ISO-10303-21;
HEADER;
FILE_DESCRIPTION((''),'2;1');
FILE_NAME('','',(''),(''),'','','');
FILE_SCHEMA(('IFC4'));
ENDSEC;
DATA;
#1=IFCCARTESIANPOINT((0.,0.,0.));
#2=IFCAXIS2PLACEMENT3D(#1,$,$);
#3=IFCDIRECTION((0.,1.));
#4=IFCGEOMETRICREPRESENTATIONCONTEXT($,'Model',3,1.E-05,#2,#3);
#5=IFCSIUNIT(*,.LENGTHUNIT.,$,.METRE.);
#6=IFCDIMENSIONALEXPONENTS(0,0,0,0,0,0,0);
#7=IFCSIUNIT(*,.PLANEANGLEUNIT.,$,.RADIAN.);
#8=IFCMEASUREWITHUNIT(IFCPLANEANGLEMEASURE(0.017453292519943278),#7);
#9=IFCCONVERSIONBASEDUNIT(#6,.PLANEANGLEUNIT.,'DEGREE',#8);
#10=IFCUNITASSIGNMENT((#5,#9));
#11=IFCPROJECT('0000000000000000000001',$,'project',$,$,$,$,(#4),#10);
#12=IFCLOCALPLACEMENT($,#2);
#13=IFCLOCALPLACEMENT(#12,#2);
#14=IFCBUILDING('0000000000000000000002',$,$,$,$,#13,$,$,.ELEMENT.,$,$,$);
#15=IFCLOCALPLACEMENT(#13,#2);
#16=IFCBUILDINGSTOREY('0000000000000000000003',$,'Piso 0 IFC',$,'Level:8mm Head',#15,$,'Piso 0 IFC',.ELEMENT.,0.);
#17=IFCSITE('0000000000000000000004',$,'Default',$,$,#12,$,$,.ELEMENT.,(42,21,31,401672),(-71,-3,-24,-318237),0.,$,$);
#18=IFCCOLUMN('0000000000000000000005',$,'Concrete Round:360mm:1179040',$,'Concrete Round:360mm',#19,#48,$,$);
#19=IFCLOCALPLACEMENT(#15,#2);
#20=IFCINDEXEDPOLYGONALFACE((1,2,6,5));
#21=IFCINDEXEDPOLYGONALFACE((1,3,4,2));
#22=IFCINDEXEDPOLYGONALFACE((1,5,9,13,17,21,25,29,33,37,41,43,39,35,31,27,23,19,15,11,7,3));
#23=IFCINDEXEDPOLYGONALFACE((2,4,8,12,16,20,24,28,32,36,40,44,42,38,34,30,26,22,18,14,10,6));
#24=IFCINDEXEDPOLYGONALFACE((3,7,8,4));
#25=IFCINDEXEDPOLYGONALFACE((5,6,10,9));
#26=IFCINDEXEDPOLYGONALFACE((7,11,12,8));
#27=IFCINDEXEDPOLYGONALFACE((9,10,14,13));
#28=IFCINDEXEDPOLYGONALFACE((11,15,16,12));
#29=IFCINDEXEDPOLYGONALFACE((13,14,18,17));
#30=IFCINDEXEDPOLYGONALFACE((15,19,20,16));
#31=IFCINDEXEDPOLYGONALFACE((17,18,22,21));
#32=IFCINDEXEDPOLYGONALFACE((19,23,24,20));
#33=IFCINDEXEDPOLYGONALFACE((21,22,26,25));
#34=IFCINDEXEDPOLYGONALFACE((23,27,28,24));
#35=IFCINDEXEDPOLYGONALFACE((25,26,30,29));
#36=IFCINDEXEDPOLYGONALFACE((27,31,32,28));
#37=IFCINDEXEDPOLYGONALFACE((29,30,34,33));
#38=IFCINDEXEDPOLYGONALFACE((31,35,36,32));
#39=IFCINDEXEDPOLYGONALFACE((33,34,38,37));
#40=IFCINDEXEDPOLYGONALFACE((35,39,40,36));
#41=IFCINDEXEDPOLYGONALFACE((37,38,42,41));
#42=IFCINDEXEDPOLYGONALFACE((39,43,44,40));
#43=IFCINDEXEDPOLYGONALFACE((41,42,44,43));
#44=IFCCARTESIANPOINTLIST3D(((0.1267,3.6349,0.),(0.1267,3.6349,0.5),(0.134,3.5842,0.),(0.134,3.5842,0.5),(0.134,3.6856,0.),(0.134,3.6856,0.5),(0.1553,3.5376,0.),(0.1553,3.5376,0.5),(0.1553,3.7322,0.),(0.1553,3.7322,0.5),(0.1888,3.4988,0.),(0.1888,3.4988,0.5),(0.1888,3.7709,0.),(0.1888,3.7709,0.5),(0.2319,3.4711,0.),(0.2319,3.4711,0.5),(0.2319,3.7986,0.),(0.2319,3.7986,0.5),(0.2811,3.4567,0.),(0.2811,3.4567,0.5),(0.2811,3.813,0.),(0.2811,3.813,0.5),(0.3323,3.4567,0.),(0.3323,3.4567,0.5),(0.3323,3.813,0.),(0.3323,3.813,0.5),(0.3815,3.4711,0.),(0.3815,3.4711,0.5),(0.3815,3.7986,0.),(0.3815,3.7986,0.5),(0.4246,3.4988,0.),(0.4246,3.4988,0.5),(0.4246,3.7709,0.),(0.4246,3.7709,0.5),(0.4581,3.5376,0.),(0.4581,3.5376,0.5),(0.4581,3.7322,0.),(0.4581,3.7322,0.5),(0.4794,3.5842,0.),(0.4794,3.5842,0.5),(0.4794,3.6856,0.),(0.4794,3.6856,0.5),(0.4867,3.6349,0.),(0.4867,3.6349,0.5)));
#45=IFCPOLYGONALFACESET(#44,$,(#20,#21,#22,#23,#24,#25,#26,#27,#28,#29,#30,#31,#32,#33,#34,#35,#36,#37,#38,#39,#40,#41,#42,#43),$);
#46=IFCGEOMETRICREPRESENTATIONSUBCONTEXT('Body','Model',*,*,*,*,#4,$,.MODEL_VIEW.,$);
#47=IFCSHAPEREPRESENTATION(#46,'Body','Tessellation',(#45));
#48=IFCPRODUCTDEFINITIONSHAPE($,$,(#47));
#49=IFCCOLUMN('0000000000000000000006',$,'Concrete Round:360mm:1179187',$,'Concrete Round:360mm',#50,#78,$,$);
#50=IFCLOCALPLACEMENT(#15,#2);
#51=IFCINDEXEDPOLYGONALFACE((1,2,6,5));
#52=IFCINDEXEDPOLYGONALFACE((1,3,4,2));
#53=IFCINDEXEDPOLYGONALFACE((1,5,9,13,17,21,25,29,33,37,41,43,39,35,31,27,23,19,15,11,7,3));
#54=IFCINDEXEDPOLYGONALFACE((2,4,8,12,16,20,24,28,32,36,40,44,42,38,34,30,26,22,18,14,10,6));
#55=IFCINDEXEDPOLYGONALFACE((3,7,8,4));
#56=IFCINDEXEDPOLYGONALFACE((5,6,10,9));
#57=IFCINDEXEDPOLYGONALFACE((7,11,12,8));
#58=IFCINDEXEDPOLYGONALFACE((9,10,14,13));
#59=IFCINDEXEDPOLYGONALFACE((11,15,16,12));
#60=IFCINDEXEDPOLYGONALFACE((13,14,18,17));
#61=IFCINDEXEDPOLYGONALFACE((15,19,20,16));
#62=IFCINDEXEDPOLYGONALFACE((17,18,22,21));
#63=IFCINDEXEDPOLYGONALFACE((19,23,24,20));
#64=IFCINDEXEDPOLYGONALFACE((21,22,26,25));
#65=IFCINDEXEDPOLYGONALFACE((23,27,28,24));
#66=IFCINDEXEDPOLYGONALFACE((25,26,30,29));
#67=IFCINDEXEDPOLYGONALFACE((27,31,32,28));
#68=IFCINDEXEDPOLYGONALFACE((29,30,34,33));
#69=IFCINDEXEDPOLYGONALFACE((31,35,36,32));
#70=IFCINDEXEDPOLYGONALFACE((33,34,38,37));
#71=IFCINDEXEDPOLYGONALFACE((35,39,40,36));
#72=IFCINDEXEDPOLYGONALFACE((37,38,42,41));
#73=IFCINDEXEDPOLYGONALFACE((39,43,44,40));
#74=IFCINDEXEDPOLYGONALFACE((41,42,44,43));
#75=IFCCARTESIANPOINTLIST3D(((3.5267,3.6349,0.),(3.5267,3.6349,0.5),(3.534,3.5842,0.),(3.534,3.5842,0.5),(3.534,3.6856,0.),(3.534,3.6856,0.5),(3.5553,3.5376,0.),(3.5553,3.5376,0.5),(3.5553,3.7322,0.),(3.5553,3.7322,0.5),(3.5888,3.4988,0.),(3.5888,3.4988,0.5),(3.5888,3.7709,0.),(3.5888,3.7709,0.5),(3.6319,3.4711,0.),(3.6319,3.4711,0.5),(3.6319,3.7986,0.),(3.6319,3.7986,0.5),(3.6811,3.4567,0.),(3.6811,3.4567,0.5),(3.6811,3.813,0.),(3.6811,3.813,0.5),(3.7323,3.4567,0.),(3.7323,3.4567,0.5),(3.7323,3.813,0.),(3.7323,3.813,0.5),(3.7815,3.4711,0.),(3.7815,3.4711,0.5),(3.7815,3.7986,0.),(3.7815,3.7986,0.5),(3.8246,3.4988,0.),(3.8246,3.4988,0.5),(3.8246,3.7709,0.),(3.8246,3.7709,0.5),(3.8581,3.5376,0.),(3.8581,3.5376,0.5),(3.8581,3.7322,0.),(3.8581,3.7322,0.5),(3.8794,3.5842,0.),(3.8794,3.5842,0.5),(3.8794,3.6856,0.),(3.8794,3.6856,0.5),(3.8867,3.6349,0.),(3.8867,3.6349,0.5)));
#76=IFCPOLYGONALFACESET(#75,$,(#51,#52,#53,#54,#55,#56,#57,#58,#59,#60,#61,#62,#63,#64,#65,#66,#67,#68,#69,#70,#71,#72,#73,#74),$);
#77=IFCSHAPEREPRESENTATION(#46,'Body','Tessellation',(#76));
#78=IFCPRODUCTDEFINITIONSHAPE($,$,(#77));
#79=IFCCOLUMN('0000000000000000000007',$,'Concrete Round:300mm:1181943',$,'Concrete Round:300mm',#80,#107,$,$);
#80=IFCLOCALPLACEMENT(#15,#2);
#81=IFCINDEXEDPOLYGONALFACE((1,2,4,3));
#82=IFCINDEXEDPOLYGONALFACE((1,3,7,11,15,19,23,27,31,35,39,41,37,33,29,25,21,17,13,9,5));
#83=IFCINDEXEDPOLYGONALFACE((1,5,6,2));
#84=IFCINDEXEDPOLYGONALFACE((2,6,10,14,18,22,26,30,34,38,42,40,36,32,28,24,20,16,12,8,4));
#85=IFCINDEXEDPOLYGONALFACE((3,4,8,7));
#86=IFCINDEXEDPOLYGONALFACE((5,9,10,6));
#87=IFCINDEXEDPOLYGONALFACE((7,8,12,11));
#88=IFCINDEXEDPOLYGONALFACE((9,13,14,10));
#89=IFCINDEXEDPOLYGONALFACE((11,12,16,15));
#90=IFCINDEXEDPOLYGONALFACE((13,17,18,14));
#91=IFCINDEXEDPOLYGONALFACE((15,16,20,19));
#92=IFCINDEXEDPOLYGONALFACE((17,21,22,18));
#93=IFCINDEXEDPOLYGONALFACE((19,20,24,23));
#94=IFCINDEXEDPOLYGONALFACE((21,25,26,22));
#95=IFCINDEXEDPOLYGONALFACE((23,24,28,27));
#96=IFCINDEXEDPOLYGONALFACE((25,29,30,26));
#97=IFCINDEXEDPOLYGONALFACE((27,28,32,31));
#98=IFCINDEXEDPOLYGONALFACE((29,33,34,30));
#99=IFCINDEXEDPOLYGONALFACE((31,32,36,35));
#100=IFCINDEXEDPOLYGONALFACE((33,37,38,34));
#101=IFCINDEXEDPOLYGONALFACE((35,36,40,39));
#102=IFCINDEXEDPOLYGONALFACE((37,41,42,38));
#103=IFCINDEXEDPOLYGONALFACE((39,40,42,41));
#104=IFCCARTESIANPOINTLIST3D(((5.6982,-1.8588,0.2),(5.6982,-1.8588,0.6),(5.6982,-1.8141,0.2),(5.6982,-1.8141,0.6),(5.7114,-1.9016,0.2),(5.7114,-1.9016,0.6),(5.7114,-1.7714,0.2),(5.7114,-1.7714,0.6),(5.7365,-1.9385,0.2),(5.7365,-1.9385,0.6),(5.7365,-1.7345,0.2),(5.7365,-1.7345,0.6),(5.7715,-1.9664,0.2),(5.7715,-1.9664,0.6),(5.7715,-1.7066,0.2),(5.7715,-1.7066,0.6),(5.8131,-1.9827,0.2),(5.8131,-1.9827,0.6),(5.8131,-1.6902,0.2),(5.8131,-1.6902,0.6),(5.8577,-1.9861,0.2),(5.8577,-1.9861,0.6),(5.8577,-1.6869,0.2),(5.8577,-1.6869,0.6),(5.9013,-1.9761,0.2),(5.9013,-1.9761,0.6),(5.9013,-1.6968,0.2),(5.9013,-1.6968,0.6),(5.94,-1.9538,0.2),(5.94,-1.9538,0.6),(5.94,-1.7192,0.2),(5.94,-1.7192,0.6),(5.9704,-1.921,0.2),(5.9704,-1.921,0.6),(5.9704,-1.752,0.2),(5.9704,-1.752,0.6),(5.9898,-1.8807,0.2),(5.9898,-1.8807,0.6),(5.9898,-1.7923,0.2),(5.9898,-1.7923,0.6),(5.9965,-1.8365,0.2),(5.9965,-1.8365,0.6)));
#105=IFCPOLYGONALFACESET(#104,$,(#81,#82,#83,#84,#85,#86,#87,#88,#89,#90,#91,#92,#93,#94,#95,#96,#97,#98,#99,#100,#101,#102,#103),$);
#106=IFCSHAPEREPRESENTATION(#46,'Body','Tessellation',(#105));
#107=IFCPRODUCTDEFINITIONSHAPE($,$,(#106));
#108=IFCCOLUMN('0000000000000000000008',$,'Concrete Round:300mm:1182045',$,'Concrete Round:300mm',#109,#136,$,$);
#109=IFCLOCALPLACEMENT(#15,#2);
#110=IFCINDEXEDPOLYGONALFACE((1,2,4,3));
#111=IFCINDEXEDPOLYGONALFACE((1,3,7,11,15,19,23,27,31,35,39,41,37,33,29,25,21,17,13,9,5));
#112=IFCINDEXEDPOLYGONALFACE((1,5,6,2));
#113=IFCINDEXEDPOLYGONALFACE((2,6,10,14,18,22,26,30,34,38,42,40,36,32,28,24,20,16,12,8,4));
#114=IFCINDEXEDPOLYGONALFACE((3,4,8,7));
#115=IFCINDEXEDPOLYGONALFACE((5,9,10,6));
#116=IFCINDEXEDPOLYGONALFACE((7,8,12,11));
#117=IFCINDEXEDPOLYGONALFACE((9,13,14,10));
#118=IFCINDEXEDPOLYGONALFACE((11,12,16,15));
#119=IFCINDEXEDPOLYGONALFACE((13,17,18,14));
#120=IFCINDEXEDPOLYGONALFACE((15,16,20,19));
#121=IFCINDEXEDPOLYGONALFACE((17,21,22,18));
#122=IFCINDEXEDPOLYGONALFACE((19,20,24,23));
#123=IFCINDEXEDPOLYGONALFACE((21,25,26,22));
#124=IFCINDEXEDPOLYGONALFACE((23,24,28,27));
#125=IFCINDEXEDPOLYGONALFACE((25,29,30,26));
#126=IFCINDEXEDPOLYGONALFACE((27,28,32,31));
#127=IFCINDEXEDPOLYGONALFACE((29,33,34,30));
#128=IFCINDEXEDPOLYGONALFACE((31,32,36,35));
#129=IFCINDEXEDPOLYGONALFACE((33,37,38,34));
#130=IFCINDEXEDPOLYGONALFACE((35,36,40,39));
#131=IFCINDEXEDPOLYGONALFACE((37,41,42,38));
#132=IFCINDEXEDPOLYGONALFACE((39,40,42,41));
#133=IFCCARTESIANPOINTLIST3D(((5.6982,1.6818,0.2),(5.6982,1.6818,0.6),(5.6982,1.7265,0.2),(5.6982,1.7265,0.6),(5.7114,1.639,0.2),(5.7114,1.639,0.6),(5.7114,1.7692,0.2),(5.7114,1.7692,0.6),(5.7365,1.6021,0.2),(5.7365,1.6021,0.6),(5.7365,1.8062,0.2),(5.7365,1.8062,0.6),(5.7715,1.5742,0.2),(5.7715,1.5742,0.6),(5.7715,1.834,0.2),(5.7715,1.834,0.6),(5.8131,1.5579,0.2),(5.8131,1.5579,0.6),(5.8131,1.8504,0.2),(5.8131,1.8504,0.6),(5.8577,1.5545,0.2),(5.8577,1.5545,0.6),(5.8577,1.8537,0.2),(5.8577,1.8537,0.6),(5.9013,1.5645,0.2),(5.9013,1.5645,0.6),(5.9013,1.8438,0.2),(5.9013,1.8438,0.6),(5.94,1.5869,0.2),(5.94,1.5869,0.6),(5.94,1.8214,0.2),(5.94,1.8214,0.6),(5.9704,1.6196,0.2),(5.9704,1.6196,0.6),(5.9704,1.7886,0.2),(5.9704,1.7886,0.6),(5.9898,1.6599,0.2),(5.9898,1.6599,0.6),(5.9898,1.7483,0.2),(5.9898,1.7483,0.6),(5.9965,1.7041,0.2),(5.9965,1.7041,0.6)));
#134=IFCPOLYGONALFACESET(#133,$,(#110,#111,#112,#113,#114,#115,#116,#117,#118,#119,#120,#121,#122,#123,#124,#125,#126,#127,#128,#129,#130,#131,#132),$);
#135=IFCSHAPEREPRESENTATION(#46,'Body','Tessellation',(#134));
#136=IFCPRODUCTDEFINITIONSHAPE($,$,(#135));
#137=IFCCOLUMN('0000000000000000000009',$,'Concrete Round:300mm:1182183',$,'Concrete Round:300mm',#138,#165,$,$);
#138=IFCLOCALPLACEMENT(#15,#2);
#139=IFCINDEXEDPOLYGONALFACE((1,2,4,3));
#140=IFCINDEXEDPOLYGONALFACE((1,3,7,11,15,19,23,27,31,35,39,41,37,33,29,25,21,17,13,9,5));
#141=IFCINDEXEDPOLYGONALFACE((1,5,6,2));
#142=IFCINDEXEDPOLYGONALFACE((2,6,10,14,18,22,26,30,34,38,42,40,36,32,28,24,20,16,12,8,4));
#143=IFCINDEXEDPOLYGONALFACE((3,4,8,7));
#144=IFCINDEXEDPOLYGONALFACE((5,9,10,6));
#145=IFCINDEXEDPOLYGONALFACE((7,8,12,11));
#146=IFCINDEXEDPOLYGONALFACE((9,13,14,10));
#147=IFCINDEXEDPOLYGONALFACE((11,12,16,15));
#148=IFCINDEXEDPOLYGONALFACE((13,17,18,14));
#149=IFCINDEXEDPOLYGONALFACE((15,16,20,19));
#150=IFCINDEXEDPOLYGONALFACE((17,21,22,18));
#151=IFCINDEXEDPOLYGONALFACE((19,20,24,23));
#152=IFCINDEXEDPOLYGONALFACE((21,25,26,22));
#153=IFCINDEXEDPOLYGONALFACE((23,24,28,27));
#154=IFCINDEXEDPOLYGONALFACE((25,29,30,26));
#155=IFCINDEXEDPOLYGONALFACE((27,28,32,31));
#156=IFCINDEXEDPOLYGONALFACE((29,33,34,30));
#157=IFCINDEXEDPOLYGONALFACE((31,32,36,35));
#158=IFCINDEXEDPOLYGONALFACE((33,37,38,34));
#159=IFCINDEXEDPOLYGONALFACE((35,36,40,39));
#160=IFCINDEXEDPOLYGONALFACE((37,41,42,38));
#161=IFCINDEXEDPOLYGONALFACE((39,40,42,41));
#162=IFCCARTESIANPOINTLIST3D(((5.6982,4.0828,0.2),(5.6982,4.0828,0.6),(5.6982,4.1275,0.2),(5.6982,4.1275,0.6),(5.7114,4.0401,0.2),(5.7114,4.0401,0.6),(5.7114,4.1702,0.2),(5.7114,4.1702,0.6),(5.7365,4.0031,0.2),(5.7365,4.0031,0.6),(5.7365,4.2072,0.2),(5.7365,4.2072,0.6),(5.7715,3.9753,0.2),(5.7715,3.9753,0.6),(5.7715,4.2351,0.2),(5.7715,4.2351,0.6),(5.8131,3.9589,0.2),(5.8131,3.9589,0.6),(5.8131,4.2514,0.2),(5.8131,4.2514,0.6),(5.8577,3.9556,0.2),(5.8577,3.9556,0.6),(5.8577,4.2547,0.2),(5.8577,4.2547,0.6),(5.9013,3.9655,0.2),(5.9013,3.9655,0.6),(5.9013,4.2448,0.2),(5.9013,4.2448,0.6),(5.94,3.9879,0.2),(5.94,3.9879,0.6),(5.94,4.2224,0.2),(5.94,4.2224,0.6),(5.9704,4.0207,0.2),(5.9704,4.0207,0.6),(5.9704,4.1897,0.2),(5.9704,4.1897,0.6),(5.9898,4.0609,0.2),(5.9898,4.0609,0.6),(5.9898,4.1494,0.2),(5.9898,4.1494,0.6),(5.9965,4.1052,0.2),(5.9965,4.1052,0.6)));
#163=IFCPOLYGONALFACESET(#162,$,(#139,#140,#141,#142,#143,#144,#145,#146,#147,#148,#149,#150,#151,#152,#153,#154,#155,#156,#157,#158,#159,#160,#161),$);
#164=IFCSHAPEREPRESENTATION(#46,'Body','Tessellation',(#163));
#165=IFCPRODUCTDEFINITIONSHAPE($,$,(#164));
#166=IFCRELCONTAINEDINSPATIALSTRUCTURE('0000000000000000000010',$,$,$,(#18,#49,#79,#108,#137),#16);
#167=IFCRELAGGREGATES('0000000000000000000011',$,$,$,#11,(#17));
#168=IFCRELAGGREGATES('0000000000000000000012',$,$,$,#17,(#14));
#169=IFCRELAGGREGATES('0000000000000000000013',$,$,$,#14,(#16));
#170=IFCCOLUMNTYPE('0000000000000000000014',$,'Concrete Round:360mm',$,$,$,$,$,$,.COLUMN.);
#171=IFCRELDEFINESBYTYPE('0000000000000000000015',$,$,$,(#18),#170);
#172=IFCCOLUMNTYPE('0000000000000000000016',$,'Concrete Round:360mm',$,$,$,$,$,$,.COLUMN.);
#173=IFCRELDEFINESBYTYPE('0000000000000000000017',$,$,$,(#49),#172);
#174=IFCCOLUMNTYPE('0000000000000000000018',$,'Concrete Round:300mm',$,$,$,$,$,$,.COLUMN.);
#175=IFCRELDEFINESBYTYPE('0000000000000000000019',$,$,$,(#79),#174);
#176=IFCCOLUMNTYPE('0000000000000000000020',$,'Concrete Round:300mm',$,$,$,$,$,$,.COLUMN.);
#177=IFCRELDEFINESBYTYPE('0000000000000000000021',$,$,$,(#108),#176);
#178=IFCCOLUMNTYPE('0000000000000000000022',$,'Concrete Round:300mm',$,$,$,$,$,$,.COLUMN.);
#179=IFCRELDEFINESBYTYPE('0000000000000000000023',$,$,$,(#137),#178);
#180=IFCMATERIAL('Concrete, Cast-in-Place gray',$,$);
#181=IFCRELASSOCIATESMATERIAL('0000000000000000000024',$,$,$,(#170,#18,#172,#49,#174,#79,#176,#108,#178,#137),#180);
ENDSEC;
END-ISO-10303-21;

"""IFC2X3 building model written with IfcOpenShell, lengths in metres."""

from ifc_helpers import new_model, entity, si_unit, converted_unit, direction, frame, frame_2d, origin, origin_2d_with_axis, place, context, subcontext, project, spatial, circle, extrude, source, transform, mapped, material, type_object, type_shapes, element, save


model = new_model("IFC2X3")

# Units and contexts
model_context = context("Model", 3, precision=1e-05, world=origin(), true_north=direction((0.0, 1.0)))
body_context = subcontext(model_context, "Body", "Model", "MODEL_VIEW")
ifc_project = project(units=[si_unit("LENGTHUNIT", "METRE"), converted_unit("PLANEANGLEUNIT", "DEGREE", entity("IfcPlaneAngleMeasure", 0.017453292519943278), si_unit("PLANEANGLEUNIT", "RADIAN"), dimensions=[0, 0, 0, 0, 0, 0, 0])], contexts=[model_context])

# Site, building, storey
site_placement = place(None, origin())
site = spatial("IfcSite", under=ifc_project, at=site_placement, Name="Default", CompositionType="ELEMENT", RefLatitude=(42, 21, 31, 401672), RefLongitude=(-71, -3, -24, -318237), RefElevation=0.0)
building_placement = place(site_placement, origin())
building = spatial("IfcBuilding", under=site, at=building_placement, CompositionType="ELEMENT")
storey_placement = place(building_placement, origin())
storey = spatial("IfcBuildingStorey", under=building, at=storey_placement, Name="Piso 0 IFC", ObjectType="Level:8mm Head", LongName="Piso 0 IFC", CompositionType="ELEMENT", Elevation=0.0)

# Columns
ifc_material_1 = material(Name="Concrete, Cast-in-Place gray")
column_type_1 = type_object("IfcColumnType", Name="Concrete Round:360mm", PredefinedType="COLUMN", material=ifc_material_1)
shared_shape_1 = source(origin(), body_context, "Body", "SweptSolid", [
    extrude(circle(Radius=0.18, at=origin_2d_with_axis()), frame((0.3067, 3.6349, 0.0)), (0.0, 0.0, 1.0), 0.5),
])
type_shapes(column_type_1, [shared_shape_1])
column_1_placement = place(storey_placement, origin())
element("IfcColumn", 1, at=column_1_placement, inside=storey, type_object=column_type_1, material=ifc_material_1, Name="Concrete Round:360mm:1179040", ObjectType="Concrete Round:360mm", context=body_context, shape_type="MappedRepresentation", body=[
    mapped(shared_shape_1, transform((0.0, 0.0, 0.0), scale=1.0)),
])
column_type_2 = type_object("IfcColumnType", Name="Concrete Round:360mm", PredefinedType="COLUMN", material=ifc_material_1)
shared_shape_2 = source(origin(), body_context, "Body", "SweptSolid", [
    extrude(circle(Radius=0.18, at=origin_2d_with_axis()), frame((3.7067, 3.6349, 0.0)), (0.0, 0.0, 1.0), 0.5),
])
type_shapes(column_type_2, [shared_shape_2])
column_2_placement = place(storey_placement, origin())
element("IfcColumn", 2, at=column_2_placement, inside=storey, type_object=column_type_2, material=ifc_material_1, Name="Concrete Round:360mm:1179187", ObjectType="Concrete Round:360mm", context=body_context, shape_type="MappedRepresentation", body=[
    mapped(shared_shape_2, transform((0.0, 0.0, 0.0), scale=1.0)),
])
column_type_3 = type_object("IfcColumnType", Name="Concrete Round:300mm", PredefinedType="COLUMN", material=ifc_material_1)
shared_shape_3 = source(origin(), body_context, "Body", "SweptSolid", [
    extrude(circle(Radius=0.15, at=frame_2d((0.0, 0.0), x_axis=(1.0, 0.0))), frame((5.8465, -1.8365, 0.2)), (0.0, 0.0, 1.0), 0.4),
])
type_shapes(column_type_3, [shared_shape_3])
column_3_placement = place(storey_placement, origin())
element("IfcColumn", 3, at=column_3_placement, inside=storey, type_object=column_type_3, material=ifc_material_1, Name="Concrete Round:300mm:1181943", ObjectType="Concrete Round:300mm", context=body_context, shape_type="MappedRepresentation", body=[
    mapped(shared_shape_3, transform((0.0, 0.0, 0.0), scale=1.0)),
])
column_type_4 = type_object("IfcColumnType", Name="Concrete Round:300mm", PredefinedType="COLUMN", material=ifc_material_1)
shared_shape_4 = source(origin(), body_context, "Body", "SweptSolid", [
    extrude(circle(Radius=0.15, at=frame_2d((0.0, 0.0), x_axis=(1.0, 0.0))), frame((5.8465, 1.7041, 0.2)), (0.0, 0.0, 1.0), 0.4),
])
type_shapes(column_type_4, [shared_shape_4])
column_4_placement = place(storey_placement, origin())
element("IfcColumn", 4, at=column_4_placement, inside=storey, type_object=column_type_4, material=ifc_material_1, Name="Concrete Round:300mm:1182045", ObjectType="Concrete Round:300mm", context=body_context, shape_type="MappedRepresentation", body=[
    mapped(shared_shape_4, transform((0.0, 0.0, 0.0), scale=1.0)),
])
column_type_5 = type_object("IfcColumnType", Name="Concrete Round:300mm", PredefinedType="COLUMN", material=ifc_material_1)
shared_shape_5 = source(origin(), body_context, "Body", "SweptSolid", [
    extrude(circle(Radius=0.15, at=frame_2d((0.0, 0.0), x_axis=(1.0, 0.0))), frame((5.8465, 4.1052, 0.2)), (0.0, 0.0, 1.0), 0.4),
])
type_shapes(column_type_5, [shared_shape_5])
column_5_placement = place(storey_placement, origin())
element("IfcColumn", 5, at=column_5_placement, inside=storey, type_object=column_type_5, material=ifc_material_1, Name="Concrete Round:300mm:1182183", ObjectType="Concrete Round:300mm", context=body_context, shape_type="MappedRepresentation", body=[
    mapped(shared_shape_5, transform((0.0, 0.0, 0.0), scale=1.0)),
])

save(model, "model.ifc")
